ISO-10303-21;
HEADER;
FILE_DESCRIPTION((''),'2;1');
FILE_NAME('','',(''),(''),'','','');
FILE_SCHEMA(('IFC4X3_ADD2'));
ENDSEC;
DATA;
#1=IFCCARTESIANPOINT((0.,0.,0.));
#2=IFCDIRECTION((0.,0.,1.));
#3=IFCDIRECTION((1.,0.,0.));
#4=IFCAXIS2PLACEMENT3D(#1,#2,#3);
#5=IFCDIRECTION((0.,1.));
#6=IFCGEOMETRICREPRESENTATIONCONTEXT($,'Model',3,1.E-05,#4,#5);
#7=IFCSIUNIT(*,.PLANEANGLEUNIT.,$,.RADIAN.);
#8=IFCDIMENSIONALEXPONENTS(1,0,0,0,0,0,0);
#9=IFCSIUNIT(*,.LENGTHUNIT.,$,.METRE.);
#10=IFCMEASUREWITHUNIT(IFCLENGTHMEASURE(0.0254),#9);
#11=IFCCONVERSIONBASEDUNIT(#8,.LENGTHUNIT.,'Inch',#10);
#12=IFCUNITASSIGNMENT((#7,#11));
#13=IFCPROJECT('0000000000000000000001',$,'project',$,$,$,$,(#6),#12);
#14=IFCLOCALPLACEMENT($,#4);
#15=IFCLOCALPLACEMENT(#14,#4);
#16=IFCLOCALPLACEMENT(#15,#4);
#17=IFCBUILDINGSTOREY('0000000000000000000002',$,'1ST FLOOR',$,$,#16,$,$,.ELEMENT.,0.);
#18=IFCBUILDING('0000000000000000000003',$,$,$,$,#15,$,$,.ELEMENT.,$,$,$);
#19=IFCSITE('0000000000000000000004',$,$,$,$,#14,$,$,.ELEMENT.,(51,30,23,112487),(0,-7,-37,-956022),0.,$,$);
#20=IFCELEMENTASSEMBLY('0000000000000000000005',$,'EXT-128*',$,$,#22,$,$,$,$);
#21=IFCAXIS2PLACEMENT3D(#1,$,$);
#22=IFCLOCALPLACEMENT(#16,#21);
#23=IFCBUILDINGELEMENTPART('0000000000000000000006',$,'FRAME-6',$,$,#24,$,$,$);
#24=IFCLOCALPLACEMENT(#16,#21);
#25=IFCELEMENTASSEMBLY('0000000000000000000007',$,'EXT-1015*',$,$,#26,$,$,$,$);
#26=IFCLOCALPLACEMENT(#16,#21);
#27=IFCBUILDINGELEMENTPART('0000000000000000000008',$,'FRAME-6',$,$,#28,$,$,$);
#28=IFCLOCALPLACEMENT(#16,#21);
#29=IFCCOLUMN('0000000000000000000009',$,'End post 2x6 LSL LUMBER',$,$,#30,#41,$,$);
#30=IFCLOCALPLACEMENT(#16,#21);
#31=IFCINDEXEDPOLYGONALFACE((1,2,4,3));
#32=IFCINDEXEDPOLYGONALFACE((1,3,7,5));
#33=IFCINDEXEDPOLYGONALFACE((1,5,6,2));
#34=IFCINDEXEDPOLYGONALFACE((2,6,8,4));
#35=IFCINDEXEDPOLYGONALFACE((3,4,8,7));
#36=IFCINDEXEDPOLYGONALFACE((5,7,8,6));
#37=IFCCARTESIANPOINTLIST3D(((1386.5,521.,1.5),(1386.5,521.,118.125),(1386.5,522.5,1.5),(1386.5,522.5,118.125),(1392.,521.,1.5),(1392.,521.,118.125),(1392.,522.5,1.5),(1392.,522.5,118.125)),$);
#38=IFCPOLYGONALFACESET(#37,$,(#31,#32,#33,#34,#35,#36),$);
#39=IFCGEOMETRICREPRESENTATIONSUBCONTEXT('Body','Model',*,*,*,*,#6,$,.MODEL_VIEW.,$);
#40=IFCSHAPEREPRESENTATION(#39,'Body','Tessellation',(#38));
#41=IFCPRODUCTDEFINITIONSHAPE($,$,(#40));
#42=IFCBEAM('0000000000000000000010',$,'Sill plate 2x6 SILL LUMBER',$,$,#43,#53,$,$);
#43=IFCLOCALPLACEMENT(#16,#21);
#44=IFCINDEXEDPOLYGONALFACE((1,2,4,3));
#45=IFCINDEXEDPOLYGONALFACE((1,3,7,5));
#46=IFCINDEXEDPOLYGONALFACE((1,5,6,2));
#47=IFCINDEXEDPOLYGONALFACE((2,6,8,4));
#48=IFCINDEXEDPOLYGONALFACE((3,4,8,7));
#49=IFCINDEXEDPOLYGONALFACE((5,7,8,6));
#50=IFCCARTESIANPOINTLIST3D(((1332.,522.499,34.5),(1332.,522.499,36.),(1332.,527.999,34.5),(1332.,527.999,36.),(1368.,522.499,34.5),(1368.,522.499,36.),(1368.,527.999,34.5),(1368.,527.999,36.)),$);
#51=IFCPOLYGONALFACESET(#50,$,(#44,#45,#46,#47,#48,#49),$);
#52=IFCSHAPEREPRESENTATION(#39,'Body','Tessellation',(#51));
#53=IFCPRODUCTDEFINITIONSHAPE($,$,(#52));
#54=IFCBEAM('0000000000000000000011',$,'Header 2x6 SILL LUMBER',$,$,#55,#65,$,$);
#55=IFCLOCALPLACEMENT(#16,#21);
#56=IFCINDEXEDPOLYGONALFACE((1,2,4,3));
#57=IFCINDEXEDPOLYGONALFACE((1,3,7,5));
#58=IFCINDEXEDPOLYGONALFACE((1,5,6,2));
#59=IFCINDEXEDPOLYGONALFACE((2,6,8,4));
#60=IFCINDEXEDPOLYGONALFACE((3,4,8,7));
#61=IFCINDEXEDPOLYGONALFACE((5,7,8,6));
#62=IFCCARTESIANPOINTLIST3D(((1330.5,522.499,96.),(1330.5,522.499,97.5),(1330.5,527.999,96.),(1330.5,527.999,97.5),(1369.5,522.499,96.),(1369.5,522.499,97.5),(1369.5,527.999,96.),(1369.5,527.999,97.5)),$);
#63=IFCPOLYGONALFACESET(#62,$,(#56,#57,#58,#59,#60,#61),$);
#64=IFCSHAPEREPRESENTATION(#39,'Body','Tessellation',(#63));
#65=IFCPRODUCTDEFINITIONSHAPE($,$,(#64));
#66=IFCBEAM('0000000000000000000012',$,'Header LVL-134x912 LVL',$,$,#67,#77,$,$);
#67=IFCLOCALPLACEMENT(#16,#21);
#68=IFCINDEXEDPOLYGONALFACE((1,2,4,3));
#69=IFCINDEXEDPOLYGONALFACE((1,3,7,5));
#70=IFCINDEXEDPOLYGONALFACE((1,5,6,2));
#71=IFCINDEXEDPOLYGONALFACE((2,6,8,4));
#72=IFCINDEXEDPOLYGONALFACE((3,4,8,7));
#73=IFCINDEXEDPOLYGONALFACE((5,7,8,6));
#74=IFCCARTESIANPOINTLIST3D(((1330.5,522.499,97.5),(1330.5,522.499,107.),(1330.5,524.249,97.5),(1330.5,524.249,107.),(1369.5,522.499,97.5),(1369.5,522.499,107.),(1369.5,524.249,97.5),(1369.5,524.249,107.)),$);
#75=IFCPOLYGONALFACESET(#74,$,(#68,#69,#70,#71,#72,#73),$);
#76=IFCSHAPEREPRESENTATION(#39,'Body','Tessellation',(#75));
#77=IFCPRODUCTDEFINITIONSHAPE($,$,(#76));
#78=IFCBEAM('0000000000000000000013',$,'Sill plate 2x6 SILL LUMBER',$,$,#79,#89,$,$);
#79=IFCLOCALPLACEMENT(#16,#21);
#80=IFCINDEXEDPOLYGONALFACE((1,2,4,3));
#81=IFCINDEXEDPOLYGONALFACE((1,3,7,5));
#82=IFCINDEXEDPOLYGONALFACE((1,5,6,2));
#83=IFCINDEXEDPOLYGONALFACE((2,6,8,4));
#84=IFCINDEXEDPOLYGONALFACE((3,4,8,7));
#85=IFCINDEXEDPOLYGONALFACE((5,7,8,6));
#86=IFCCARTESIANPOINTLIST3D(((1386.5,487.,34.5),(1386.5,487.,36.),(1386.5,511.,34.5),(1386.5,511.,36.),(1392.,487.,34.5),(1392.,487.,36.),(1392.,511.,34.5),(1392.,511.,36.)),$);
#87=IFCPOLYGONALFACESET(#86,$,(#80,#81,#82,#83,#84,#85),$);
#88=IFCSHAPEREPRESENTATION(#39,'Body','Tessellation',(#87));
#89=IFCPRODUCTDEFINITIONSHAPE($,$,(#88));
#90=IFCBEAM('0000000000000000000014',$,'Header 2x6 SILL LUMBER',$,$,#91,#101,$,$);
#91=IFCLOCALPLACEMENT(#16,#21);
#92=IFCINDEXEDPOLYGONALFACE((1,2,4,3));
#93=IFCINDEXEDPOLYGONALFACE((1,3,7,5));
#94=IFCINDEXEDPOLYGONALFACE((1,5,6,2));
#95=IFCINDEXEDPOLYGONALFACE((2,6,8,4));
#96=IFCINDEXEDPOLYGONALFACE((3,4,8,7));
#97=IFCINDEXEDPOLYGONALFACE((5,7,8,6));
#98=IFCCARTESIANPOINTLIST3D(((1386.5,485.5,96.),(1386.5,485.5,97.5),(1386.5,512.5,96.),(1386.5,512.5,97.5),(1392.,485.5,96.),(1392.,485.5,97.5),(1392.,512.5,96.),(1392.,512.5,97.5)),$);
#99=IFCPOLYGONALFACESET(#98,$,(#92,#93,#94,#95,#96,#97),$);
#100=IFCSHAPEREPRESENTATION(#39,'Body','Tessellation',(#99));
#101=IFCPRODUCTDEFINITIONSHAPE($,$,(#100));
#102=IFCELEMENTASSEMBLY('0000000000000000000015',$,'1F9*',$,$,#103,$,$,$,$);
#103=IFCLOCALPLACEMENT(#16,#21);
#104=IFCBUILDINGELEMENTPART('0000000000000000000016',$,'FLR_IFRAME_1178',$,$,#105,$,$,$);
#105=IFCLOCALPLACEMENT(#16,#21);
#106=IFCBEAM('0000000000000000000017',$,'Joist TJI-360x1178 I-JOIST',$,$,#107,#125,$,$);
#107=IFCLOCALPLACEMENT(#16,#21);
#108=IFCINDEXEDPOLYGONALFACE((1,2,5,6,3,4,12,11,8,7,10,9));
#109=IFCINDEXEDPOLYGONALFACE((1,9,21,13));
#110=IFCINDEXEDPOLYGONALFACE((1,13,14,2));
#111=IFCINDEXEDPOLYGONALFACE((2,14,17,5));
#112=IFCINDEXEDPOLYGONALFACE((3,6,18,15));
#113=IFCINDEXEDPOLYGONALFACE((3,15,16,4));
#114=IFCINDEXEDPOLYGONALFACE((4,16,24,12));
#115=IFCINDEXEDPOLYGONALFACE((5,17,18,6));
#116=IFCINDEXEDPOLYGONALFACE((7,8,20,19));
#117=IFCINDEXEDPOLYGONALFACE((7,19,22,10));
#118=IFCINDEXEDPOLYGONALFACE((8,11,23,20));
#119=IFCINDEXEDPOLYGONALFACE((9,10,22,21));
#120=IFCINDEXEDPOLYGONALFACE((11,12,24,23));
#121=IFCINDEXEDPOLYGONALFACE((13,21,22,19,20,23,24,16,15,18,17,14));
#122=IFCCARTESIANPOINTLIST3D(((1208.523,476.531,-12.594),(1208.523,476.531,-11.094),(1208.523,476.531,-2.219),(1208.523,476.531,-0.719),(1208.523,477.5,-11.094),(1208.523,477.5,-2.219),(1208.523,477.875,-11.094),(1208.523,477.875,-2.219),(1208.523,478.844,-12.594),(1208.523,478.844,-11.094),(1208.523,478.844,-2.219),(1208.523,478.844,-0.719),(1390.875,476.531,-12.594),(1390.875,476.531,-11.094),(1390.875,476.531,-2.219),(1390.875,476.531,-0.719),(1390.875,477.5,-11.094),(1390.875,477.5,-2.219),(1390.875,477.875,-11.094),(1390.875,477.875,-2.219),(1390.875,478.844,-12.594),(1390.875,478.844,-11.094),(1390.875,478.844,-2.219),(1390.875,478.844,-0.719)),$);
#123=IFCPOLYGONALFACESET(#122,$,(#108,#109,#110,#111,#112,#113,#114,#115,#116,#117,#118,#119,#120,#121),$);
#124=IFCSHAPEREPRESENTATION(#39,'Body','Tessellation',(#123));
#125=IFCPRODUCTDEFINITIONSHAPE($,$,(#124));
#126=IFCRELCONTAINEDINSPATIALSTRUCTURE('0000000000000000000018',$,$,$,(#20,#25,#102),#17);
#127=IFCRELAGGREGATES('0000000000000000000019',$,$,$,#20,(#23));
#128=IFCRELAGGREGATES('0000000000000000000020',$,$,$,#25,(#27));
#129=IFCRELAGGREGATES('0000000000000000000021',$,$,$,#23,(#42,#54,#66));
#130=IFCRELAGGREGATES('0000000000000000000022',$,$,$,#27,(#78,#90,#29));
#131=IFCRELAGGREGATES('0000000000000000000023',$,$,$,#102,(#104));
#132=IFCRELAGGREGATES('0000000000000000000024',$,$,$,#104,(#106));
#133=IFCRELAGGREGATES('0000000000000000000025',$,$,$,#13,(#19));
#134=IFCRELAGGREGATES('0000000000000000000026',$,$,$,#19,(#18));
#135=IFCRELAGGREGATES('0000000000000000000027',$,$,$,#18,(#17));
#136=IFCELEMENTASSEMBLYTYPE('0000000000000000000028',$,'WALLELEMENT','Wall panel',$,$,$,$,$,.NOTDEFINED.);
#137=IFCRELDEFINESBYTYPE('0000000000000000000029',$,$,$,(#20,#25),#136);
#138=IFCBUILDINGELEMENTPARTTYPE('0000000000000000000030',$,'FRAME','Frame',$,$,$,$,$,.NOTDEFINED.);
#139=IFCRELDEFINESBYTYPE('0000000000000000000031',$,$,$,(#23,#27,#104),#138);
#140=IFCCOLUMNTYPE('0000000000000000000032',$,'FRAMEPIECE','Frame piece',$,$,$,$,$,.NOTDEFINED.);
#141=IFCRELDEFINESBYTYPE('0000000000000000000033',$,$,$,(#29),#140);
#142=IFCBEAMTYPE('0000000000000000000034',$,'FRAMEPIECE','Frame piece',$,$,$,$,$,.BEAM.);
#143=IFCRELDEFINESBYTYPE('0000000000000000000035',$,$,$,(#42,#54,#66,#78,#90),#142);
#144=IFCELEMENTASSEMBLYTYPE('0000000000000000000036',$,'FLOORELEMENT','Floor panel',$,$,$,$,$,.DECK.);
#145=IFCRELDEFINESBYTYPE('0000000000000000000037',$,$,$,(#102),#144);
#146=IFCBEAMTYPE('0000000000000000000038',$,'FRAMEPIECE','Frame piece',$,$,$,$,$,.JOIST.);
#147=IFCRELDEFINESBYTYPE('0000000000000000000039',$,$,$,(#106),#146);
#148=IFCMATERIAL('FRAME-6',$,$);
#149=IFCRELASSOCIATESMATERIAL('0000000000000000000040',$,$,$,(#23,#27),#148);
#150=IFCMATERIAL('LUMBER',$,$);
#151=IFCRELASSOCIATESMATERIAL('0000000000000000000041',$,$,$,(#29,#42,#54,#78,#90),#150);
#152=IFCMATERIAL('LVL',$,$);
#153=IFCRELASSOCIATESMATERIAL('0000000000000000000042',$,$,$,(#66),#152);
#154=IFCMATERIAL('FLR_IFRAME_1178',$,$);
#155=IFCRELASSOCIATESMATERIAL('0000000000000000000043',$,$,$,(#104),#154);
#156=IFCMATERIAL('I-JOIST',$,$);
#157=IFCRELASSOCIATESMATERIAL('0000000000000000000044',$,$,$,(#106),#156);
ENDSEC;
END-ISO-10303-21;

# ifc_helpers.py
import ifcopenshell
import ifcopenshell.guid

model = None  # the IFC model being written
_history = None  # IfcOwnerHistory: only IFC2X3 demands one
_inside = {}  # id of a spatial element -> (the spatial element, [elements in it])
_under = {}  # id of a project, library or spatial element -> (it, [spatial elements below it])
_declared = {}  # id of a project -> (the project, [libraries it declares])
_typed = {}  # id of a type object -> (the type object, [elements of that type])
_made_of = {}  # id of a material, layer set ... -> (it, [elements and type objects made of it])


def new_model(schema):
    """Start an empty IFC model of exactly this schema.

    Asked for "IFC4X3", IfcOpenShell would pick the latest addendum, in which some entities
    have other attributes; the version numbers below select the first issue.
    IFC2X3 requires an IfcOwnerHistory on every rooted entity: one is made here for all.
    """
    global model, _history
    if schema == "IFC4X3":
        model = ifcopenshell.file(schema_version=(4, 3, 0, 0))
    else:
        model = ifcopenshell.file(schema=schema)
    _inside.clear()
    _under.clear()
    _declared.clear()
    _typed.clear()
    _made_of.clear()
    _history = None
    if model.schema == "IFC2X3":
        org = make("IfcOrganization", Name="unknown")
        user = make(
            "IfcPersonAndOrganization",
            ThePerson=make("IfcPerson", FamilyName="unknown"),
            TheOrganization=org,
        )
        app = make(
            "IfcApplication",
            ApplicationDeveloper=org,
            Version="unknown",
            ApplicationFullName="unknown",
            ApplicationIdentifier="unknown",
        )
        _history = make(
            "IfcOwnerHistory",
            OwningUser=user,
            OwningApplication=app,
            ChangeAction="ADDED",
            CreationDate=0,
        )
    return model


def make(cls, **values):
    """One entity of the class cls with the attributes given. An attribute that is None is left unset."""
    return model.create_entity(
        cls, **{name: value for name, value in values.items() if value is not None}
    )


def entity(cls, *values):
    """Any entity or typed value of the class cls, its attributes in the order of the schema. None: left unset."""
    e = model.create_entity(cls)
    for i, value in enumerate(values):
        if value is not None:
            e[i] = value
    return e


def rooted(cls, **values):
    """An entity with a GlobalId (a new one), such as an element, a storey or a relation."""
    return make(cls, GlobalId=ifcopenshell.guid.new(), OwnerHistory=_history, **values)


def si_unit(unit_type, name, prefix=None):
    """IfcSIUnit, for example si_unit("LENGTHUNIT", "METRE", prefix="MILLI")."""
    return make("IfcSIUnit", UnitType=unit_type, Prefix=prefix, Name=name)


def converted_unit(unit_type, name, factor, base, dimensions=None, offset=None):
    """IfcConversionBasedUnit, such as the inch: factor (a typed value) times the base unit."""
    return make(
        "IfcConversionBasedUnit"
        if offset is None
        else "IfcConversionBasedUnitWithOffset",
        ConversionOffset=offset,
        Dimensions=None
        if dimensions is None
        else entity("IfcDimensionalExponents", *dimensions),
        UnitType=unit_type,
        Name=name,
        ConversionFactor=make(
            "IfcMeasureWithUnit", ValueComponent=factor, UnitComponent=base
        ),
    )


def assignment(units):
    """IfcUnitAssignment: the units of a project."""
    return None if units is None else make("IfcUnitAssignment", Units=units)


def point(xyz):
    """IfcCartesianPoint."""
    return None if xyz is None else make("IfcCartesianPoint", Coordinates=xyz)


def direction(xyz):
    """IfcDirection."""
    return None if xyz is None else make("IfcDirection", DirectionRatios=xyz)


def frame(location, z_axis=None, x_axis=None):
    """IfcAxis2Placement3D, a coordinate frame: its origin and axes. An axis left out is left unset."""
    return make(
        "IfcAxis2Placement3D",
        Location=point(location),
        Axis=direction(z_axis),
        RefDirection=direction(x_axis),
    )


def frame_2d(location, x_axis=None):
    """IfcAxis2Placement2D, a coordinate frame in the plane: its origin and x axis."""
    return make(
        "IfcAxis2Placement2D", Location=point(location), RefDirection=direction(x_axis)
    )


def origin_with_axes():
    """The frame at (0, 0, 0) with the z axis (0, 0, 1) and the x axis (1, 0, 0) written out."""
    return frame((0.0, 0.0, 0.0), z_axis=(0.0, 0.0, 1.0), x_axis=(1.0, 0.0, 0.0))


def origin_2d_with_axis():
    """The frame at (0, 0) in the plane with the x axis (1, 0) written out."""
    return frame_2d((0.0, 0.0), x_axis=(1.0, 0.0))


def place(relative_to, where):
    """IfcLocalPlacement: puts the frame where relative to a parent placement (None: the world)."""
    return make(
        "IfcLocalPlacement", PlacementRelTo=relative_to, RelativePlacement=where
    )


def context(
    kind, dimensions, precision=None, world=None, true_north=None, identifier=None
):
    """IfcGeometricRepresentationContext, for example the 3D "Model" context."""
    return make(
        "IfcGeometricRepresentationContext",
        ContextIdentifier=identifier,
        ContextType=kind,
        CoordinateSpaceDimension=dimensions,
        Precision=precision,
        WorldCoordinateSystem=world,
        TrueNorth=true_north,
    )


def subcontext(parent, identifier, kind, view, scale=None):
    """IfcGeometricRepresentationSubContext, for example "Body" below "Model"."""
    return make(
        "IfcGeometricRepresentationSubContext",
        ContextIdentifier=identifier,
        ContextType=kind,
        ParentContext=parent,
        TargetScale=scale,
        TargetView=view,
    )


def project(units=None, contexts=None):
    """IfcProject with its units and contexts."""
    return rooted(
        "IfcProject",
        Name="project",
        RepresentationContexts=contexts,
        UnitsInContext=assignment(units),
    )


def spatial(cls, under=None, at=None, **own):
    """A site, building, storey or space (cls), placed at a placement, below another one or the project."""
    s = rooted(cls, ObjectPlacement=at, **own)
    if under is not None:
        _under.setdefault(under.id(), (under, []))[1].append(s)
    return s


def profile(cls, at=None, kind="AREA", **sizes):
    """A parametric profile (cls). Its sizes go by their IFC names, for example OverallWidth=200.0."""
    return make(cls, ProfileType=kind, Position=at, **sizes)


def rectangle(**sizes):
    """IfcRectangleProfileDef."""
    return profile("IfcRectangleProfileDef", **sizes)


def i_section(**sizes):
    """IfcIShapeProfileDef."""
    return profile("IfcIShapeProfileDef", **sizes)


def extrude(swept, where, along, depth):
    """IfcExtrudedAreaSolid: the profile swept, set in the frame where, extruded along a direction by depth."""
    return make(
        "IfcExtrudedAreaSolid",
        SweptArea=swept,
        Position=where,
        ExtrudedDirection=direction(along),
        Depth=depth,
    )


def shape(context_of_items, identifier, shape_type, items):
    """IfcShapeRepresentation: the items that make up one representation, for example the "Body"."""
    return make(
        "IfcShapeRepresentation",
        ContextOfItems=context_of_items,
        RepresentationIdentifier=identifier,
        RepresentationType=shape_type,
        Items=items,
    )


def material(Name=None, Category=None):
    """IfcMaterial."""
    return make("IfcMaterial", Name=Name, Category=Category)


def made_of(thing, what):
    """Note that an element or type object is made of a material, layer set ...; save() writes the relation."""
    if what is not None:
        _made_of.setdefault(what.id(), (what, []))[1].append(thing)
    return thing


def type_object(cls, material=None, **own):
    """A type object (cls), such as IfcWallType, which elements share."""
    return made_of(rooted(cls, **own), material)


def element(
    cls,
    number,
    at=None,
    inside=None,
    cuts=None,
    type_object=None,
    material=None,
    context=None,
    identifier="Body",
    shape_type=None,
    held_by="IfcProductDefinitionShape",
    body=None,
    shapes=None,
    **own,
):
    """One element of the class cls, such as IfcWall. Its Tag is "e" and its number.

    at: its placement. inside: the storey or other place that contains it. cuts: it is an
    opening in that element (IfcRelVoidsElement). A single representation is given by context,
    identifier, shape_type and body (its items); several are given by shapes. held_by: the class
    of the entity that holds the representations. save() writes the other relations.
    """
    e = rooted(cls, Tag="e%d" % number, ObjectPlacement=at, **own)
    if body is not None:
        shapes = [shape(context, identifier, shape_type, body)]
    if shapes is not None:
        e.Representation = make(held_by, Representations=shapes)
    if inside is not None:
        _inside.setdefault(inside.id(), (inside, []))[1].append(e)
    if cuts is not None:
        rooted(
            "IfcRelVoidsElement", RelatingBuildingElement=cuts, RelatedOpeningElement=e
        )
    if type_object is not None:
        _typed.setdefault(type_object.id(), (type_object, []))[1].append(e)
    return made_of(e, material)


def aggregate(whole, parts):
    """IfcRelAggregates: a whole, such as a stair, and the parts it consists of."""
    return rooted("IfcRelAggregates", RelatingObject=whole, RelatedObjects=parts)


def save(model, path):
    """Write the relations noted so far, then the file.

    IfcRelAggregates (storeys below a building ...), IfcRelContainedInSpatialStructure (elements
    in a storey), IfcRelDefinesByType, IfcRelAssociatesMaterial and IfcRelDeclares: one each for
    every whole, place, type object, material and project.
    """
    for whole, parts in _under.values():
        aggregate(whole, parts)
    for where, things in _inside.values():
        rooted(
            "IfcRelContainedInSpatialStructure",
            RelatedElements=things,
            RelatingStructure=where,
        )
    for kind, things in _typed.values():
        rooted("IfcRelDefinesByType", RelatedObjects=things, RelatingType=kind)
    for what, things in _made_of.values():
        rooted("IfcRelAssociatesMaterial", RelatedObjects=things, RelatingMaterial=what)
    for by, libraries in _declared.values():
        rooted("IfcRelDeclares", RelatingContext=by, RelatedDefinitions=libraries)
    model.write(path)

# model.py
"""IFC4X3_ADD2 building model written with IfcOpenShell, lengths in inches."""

from ifc_helpers import new_model, entity, si_unit, converted_unit, direction, frame, origin_with_axes, origin_2d_with_axis, place, context, subcontext, project, spatial, rectangle, i_section, extrude, material, type_object, element, aggregate, save


model = new_model("IFC4X3_ADD2")

# Units and contexts
model_context = context("Model", 3, precision=1e-05, world=origin_with_axes(), true_north=direction((0.0, 1.0)))
body_context = subcontext(model_context, "Body", "Model", "MODEL_VIEW")
ifc_project = project(units=[si_unit("PLANEANGLEUNIT", "RADIAN"), converted_unit("LENGTHUNIT", "Inch", entity("IfcLengthMeasure", 0.0254), si_unit("LENGTHUNIT", "METRE"), dimensions=[1, 0, 0, 0, 0, 0, 0])], contexts=[model_context])

# Site, building, storey
site_placement = place(None, origin_with_axes())
site = spatial("IfcSite", under=ifc_project, at=site_placement, CompositionType="ELEMENT", RefLatitude=(51, 30, 23, 112487), RefLongitude=(0, -7, -37, -956022), RefElevation=0.0)
building_placement = place(site_placement, origin_with_axes())
building = spatial("IfcBuilding", under=site, at=building_placement, CompositionType="ELEMENT")
storey_placement = place(building_placement, origin_with_axes())
storey = spatial("IfcBuildingStorey", under=building, at=storey_placement, Name="1ST FLOOR", CompositionType="ELEMENT", Elevation=0.0)

# Element assemblies, building element parts, column
element_assembly_type_1 = type_object("IfcElementAssemblyType", Name="WALLELEMENT", Description="Wall panel", PredefinedType="NOTDEFINED")
assembly_1_placement = place(storey_placement, origin_with_axes())
assembly_1 = element("IfcElementAssembly", 1, at=assembly_1_placement, inside=storey, type_object=element_assembly_type_1, Name="EXT-128*")
ifc_material_1 = material(Name="FRAME-6")
building_element_part_type = type_object("IfcBuildingElementPartType", Name="FRAME", Description="Frame", PredefinedType="NOTDEFINED")
building_element_part_1_placement = place(storey_placement, origin_with_axes())
building_element_part_1 = element("IfcBuildingElementPart", 2, at=building_element_part_1_placement, type_object=building_element_part_type, material=ifc_material_1, Name="FRAME-6")
aggregate(assembly_1, [building_element_part_1])
ifc_material_2 = material(Name="LUMBER")
column_type = type_object("IfcColumnType", Name="FRAMEPIECE", Description="Frame piece", PredefinedType="NOTDEFINED")
assembly_2_placement = place(storey_placement, origin_with_axes())
assembly_2 = element("IfcElementAssembly", 3, at=assembly_2_placement, inside=storey, type_object=element_assembly_type_1, Name="EXT-1015*")
building_element_part_2_placement = place(storey_placement, origin_with_axes())
building_element_part_2 = element("IfcBuildingElementPart", 4, at=building_element_part_2_placement, type_object=building_element_part_type, material=ifc_material_1, Name="FRAME-6")
aggregate(assembly_2, [building_element_part_2])
column_1_placement = place(storey_placement, frame((1389.25, 521.75, 1.5), z_axis=(0.0, 0.0, 1.0), x_axis=(0.0, -1.0, 0.0)))
column_1 = element("IfcColumn", 5, at=column_1_placement, type_object=column_type, material=ifc_material_2, Name="End post 2x6 LSL LUMBER", context=body_context, shape_type="SweptSolid", body=[
    extrude(rectangle(XDim=1.5, YDim=5.5, at=origin_2d_with_axis()), origin_with_axes(), (0.0, 0.0, 1.0), 116.625),
])

# Beams
beam_type_1 = type_object("IfcBeamType", Name="FRAMEPIECE", Description="Frame piece", PredefinedType="BEAM")
beam_1_placement = place(storey_placement, frame((1368.0, 525.249, 35.25), z_axis=(-1.0, 0.0, 0.0), x_axis=(0.0, 0.0, -1.0)))
beam_1 = element("IfcBeam", 6, at=beam_1_placement, type_object=beam_type_1, material=ifc_material_2, Name="Sill plate 2x6 SILL LUMBER", context=body_context, shape_type="SweptSolid", body=[
    extrude(rectangle(XDim=1.5, YDim=5.5, at=origin_2d_with_axis()), origin_with_axes(), (0.0, 0.0, 1.0), 36.0),
])
beam_2_placement = place(storey_placement, frame((1330.5, 525.249, 96.75), z_axis=(1.0, 0.0, 0.0), x_axis=(0.0, 0.0, 1.0)))
beam_2 = element("IfcBeam", 7, at=beam_2_placement, type_object=beam_type_1, material=ifc_material_2, Name="Header 2x6 SILL LUMBER", context=body_context, shape_type="SweptSolid", body=[
    extrude(rectangle(XDim=1.5, YDim=5.5, at=origin_2d_with_axis()), origin_with_axes(), (0.0, 0.0, 1.0), 39.0),
])
ifc_material_3 = material(Name="LVL")
beam_3_placement = place(storey_placement, frame((1330.5, 523.374, 102.25), z_axis=(1.0, 0.0, 0.0), x_axis=(0.0, 1.0, 0.0)))
beam_3 = element("IfcBeam", 8, at=beam_3_placement, type_object=beam_type_1, material=ifc_material_3, Name="Header LVL-134x912 LVL", context=body_context, shape_type="SweptSolid", body=[
    extrude(rectangle(XDim=1.75, YDim=9.5, at=origin_2d_with_axis()), origin_with_axes(), (0.0, 0.0, 1.0), 39.0),
])
aggregate(building_element_part_1, [beam_1, beam_2, beam_3])
beam_4_placement = place(storey_placement, frame((1389.25, 511.0, 35.25), z_axis=(0.0, -1.0, 0.0), x_axis=(0.0, 0.0, -1.0)))
beam_4 = element("IfcBeam", 9, at=beam_4_placement, type_object=beam_type_1, material=ifc_material_2, Name="Sill plate 2x6 SILL LUMBER", context=body_context, shape_type="SweptSolid", body=[
    extrude(rectangle(XDim=1.5, YDim=5.5, at=origin_2d_with_axis()), origin_with_axes(), (0.0, 0.0, 1.0), 24.0),
])
beam_5_placement = place(storey_placement, frame((1389.25, 485.5, 96.75), z_axis=(0.0, 1.0, 0.0), x_axis=(0.0, 0.0, 1.0)))
beam_5 = element("IfcBeam", 10, at=beam_5_placement, type_object=beam_type_1, material=ifc_material_2, Name="Header 2x6 SILL LUMBER", context=body_context, shape_type="SweptSolid", body=[
    extrude(rectangle(XDim=1.5, YDim=5.5, at=origin_2d_with_axis()), origin_with_axes(), (0.0, 0.0, 1.0), 27.0),
])
aggregate(building_element_part_2, [beam_4, beam_5, column_1])

# Element assembly, building element part, beam
element_assembly_type_2 = type_object("IfcElementAssemblyType", Name="FLOORELEMENT", Description="Floor panel", PredefinedType="DECK")
assembly_3_placement = place(storey_placement, origin_with_axes())
assembly_3 = element("IfcElementAssembly", 11, at=assembly_3_placement, inside=storey, type_object=element_assembly_type_2, Name="1F9*")
ifc_material_4 = material(Name="FLR_IFRAME_1178")
building_element_part_3_placement = place(storey_placement, origin_with_axes())
building_element_part_3 = element("IfcBuildingElementPart", 12, at=building_element_part_3_placement, type_object=building_element_part_type, material=ifc_material_4, Name="FLR_IFRAME_1178")
aggregate(assembly_3, [building_element_part_3])
ifc_material_5 = material(Name="I-JOIST")
beam_type_2 = type_object("IfcBeamType", Name="FRAMEPIECE", Description="Frame piece", PredefinedType="JOIST")
beam_6_placement = place(storey_placement, frame((1390.875, 477.688, -6.656), z_axis=(-1.0, 0.0, 0.0), x_axis=(0.0, -1.0, 0.0)))
beam_6 = element("IfcBeam", 13, at=beam_6_placement, type_object=beam_type_2, material=ifc_material_5, Name="Joist TJI-360x1178 I-JOIST", context=body_context, shape_type="SweptSolid", body=[
    extrude(i_section(OverallWidth=2.313, OverallDepth=11.875, WebThickness=0.375, FlangeThickness=1.5, at=origin_2d_with_axis()), origin_with_axes(), (0.0, 0.0, 1.0), 182.352),
])
aggregate(building_element_part_3, [beam_6])

save(model, "model.ifc")
